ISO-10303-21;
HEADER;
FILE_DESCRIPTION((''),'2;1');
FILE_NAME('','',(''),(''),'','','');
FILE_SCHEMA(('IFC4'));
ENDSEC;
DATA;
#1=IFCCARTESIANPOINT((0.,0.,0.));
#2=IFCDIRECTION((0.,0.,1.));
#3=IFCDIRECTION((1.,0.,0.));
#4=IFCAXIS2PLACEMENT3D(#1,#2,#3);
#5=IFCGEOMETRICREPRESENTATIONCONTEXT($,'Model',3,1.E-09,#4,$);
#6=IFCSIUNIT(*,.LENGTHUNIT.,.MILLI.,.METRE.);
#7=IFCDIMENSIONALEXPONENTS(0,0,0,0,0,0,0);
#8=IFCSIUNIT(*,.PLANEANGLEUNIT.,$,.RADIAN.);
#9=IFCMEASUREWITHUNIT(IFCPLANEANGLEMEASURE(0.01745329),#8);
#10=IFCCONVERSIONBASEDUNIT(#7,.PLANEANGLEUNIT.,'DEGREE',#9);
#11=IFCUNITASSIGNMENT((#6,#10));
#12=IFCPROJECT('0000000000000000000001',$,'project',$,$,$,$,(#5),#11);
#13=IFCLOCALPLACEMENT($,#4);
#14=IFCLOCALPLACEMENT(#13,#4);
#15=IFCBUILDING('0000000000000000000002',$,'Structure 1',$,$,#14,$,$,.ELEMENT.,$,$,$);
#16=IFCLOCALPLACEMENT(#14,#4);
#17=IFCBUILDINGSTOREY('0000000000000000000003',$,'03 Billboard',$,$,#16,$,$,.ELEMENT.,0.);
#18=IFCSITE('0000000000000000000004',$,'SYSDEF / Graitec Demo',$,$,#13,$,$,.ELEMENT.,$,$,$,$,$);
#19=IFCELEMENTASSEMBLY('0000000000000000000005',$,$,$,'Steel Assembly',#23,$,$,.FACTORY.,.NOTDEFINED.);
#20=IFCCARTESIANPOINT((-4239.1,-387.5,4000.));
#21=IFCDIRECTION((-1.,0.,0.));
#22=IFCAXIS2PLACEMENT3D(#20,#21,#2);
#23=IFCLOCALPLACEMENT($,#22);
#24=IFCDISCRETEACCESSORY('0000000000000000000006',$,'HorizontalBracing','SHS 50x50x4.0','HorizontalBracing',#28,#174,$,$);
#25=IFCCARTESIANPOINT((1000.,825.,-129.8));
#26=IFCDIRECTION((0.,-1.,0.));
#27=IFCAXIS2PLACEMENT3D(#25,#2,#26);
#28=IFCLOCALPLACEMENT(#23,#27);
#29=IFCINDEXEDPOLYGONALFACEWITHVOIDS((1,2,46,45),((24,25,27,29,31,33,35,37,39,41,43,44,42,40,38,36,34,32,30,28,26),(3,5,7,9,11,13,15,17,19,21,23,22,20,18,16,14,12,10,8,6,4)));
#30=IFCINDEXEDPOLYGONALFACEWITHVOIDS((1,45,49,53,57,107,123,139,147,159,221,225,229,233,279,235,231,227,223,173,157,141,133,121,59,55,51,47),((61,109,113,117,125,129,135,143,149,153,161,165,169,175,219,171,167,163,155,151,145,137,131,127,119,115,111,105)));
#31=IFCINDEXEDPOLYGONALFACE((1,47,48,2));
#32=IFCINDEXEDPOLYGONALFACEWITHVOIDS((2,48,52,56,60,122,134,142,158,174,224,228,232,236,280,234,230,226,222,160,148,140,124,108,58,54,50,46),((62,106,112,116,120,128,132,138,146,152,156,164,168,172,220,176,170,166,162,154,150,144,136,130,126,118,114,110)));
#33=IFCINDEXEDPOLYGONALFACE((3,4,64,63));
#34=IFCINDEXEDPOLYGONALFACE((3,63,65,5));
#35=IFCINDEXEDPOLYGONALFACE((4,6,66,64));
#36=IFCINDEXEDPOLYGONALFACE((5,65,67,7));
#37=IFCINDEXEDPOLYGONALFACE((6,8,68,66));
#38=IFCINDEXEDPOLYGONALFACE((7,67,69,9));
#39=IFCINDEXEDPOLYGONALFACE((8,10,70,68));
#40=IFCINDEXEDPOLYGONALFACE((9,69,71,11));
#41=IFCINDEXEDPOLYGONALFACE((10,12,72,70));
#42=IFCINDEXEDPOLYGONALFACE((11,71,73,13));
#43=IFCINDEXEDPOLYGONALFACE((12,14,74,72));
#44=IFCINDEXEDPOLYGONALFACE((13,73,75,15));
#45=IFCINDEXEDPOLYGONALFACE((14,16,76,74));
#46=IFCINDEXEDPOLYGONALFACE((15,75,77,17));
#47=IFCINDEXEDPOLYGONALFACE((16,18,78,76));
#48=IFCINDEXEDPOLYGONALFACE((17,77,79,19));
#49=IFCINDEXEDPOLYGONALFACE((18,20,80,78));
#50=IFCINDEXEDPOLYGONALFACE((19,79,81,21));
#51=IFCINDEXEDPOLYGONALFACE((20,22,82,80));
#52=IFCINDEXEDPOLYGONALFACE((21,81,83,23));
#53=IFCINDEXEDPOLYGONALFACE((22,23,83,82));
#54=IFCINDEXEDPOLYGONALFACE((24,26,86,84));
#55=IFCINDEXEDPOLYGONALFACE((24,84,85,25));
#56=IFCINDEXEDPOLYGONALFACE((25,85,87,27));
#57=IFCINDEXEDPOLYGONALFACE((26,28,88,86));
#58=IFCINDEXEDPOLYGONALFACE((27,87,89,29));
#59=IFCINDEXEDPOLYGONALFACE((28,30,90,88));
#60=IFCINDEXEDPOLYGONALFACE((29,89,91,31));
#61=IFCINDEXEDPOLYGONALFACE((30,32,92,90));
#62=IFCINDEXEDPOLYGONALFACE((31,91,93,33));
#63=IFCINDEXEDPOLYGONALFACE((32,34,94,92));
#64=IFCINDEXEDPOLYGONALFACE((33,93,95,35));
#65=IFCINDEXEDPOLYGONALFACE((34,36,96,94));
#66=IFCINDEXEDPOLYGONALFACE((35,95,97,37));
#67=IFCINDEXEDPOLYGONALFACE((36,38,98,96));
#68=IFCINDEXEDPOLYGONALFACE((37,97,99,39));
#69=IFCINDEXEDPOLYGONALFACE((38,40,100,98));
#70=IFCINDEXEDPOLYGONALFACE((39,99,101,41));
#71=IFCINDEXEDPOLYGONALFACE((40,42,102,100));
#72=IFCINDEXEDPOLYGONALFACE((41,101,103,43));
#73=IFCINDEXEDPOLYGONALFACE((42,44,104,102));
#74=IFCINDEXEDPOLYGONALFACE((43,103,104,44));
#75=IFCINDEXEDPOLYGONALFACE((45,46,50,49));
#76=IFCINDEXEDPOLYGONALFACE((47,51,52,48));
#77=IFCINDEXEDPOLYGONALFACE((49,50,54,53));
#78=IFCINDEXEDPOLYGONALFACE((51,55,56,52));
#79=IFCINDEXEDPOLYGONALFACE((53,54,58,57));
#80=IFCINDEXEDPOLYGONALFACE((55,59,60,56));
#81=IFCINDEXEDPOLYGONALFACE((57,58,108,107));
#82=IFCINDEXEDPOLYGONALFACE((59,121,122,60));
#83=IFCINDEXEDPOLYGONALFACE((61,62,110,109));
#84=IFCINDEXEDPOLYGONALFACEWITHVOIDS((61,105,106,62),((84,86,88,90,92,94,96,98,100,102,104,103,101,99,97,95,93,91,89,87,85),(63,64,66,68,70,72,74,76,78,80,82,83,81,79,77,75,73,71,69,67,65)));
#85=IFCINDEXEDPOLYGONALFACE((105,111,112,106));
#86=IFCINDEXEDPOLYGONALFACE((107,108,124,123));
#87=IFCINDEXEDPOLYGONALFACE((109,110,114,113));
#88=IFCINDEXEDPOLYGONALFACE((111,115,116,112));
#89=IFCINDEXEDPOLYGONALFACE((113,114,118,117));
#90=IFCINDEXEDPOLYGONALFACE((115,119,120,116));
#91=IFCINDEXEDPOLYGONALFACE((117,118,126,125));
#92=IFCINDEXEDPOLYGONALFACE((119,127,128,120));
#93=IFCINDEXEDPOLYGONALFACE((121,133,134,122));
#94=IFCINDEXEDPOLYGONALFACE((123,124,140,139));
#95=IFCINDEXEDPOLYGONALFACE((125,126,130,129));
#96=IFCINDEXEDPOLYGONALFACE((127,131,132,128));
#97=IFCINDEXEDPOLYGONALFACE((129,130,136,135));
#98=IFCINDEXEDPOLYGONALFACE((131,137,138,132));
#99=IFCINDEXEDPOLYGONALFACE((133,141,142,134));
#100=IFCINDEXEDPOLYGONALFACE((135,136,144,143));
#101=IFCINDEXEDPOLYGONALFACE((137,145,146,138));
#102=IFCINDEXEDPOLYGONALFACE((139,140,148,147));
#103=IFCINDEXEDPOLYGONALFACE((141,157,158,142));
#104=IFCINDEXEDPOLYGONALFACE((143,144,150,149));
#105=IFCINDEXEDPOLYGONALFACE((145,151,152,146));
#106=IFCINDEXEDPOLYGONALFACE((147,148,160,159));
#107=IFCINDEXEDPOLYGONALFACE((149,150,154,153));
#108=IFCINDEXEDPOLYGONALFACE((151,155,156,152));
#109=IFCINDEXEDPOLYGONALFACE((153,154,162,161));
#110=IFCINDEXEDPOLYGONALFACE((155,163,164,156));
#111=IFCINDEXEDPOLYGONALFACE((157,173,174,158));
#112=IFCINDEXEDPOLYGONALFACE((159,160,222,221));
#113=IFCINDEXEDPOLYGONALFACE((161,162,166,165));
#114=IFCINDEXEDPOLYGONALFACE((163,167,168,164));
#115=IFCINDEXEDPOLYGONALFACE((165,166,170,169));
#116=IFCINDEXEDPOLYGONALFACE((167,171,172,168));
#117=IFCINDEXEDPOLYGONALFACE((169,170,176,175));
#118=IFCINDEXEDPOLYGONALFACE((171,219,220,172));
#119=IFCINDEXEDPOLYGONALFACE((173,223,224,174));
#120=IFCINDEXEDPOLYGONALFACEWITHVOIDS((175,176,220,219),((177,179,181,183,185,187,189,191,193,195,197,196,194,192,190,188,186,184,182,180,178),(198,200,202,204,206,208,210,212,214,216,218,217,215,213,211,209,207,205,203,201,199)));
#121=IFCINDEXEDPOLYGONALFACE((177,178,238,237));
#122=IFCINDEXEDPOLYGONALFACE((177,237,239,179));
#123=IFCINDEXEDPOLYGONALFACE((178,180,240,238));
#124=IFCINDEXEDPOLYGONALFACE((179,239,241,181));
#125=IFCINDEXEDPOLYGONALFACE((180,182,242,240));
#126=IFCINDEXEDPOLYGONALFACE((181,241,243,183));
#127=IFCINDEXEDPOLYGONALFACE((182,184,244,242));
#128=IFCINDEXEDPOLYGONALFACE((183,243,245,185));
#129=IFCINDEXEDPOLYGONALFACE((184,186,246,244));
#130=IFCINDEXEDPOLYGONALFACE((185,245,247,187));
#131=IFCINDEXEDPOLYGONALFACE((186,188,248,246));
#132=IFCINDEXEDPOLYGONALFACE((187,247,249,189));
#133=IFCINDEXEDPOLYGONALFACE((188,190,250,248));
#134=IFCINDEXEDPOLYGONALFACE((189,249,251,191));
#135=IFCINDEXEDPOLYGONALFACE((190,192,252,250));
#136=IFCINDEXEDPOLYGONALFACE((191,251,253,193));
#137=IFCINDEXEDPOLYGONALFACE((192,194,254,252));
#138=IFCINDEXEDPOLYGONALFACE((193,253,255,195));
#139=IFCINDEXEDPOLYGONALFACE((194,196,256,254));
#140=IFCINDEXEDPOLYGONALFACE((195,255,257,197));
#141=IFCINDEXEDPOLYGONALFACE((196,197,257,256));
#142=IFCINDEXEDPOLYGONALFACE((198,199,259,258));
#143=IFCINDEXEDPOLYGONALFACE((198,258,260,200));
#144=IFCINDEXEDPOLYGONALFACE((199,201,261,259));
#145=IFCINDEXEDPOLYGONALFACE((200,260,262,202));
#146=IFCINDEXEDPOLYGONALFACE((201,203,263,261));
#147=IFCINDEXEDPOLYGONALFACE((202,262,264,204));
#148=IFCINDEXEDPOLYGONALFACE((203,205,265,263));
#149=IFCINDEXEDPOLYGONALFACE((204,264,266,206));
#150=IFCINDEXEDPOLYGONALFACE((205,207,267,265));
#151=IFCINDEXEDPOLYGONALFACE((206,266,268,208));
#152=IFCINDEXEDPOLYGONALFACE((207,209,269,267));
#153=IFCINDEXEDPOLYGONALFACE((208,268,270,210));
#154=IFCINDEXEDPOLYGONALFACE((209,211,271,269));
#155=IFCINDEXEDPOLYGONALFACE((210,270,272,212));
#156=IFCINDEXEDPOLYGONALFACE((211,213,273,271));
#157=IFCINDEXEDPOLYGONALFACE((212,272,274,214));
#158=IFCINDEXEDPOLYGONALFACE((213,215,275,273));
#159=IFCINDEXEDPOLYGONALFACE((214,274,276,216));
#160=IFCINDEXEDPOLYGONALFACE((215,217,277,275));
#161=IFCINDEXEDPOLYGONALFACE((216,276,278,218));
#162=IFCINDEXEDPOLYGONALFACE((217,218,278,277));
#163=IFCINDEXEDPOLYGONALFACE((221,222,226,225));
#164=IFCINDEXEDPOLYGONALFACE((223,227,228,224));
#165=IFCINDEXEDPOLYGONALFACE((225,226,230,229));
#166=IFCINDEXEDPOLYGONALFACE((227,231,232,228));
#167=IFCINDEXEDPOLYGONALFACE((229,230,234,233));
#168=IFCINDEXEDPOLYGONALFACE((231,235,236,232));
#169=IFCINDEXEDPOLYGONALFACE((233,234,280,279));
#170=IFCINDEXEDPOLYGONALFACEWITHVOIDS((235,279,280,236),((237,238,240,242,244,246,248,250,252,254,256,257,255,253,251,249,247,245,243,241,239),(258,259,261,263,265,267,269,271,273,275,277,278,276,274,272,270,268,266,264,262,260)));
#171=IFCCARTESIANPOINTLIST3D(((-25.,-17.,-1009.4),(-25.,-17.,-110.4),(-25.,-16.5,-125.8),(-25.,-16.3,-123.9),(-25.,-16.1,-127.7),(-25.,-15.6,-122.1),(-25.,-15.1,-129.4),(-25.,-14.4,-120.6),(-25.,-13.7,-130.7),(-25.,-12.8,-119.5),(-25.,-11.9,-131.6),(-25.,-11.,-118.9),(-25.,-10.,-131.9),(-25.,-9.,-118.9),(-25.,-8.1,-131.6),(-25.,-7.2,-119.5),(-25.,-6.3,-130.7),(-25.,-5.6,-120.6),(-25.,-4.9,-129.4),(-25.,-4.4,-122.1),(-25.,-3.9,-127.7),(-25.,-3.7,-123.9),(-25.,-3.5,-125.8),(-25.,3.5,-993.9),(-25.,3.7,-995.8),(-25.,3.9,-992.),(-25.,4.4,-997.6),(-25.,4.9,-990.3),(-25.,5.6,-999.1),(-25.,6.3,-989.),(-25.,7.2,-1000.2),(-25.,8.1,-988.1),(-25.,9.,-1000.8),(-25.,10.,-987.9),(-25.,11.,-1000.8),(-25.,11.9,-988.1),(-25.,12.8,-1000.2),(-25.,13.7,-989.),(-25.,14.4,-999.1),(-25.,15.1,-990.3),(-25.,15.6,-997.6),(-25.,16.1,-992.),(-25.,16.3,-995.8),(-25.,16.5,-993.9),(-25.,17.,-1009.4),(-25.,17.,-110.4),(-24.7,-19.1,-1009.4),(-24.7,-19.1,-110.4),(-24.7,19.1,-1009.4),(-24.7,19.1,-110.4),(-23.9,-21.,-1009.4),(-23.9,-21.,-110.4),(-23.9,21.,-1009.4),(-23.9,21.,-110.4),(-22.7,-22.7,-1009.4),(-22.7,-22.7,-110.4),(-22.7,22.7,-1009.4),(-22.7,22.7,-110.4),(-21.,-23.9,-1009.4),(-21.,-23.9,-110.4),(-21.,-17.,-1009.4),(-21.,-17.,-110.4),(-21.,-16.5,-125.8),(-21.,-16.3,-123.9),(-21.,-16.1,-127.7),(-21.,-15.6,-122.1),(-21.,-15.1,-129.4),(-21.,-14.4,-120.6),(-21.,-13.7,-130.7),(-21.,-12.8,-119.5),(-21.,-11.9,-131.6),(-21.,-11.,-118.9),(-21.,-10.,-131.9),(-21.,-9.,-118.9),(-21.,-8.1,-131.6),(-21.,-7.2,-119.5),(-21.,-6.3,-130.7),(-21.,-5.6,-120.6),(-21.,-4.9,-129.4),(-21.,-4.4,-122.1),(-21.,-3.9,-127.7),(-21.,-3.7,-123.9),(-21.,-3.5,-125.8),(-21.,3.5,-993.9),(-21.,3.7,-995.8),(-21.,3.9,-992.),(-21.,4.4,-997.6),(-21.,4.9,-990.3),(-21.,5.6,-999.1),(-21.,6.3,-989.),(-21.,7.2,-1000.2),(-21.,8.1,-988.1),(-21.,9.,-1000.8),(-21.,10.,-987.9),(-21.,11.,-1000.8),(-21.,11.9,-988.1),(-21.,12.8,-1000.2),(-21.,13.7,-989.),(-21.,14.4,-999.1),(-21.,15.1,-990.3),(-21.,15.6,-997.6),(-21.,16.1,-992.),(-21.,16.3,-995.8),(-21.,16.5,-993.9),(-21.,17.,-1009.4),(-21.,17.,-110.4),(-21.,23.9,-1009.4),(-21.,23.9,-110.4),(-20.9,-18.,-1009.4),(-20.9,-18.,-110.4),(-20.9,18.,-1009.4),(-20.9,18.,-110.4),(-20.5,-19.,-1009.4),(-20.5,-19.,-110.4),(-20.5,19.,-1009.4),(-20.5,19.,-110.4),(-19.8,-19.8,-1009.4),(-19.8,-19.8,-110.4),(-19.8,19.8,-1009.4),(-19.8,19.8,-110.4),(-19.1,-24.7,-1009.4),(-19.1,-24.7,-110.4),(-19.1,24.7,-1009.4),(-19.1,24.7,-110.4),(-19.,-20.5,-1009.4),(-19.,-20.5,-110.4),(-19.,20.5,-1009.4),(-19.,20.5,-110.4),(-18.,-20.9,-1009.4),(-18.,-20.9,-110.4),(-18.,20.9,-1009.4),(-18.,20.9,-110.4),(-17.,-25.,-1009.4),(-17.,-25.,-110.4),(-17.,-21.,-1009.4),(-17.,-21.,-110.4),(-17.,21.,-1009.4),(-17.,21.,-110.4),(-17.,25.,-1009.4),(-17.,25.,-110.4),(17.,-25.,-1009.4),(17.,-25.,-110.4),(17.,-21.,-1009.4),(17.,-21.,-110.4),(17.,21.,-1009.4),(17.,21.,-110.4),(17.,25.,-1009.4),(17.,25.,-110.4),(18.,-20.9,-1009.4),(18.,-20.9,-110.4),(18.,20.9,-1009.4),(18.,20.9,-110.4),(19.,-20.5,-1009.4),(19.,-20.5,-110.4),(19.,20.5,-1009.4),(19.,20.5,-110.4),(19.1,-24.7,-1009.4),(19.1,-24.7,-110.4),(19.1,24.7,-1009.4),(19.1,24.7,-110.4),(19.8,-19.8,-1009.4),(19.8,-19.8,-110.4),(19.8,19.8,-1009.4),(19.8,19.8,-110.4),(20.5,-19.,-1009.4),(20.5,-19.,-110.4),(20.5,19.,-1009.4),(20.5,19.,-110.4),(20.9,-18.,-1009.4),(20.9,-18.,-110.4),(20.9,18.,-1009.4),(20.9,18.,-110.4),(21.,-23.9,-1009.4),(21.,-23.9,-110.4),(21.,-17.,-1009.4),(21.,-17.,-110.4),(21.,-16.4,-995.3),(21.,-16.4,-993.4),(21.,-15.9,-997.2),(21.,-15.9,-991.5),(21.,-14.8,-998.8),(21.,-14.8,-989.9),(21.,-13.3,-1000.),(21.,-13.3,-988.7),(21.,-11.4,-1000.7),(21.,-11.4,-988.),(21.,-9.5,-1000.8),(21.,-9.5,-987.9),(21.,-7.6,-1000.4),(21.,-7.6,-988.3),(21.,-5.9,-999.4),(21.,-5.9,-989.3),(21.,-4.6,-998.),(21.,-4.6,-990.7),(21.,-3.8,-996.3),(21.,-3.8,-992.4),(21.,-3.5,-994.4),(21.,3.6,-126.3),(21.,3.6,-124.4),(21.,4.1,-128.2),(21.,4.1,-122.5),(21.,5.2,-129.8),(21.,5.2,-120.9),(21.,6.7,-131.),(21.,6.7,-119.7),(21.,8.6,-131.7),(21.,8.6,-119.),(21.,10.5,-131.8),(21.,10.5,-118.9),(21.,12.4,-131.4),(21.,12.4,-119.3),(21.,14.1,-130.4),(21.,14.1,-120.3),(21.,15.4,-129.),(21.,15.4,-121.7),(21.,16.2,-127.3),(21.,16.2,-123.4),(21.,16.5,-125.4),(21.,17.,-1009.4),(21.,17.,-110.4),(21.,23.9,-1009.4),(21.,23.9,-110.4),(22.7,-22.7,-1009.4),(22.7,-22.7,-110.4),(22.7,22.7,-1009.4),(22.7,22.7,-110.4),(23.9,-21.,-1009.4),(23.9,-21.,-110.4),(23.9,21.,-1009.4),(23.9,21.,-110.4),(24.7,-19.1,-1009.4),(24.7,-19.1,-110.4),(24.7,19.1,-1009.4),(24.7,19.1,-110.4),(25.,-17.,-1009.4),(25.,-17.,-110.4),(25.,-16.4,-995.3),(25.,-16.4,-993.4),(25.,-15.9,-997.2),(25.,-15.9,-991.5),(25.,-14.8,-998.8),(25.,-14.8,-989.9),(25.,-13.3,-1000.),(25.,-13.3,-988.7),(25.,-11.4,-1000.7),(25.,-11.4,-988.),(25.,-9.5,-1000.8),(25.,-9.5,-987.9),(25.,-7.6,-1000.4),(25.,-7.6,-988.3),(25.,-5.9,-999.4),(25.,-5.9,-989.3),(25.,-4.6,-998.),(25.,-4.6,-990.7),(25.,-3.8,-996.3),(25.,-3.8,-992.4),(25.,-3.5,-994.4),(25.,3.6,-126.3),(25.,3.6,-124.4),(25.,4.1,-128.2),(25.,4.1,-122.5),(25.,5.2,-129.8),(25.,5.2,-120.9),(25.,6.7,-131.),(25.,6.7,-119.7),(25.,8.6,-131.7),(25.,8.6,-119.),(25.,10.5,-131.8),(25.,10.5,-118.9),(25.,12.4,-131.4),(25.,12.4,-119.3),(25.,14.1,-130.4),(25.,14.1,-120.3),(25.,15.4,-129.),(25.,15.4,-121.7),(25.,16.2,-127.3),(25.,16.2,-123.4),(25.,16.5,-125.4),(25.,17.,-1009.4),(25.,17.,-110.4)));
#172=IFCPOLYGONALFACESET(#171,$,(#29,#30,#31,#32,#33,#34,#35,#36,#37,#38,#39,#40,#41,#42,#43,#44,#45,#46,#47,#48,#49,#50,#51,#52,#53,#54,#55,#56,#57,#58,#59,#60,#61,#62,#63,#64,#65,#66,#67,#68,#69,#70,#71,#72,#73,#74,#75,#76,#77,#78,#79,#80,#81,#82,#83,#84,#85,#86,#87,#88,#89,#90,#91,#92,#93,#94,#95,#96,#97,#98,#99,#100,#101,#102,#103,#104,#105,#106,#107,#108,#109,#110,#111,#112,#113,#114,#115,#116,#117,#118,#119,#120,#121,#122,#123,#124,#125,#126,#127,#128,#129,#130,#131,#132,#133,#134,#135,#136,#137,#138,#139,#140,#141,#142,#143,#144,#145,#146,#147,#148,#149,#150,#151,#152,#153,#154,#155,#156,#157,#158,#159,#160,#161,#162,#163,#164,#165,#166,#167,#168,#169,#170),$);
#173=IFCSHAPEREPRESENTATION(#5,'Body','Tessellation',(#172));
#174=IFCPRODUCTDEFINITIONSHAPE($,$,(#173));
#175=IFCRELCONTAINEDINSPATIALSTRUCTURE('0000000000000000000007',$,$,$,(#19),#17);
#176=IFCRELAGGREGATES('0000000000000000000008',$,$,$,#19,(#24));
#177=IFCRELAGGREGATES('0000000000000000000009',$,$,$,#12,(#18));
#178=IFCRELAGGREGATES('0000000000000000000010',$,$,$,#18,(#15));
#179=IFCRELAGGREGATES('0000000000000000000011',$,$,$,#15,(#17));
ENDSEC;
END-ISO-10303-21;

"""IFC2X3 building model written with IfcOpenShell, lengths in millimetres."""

from ifc_helpers import new_model, entity, si_unit, converted_unit, frame, frame_2d, origin, origin_with_axes, origin_2d, origin_2d_with_axis, place, context, project, spatial, hollow_rectangle, circle, extrude, clip, halfspace, element, aggregate, save


model = new_model("IFC2X3")

# Units and contexts
model_context = context("Model", 3, precision=1e-09, world=origin_with_axes())
ifc_project = project(units=[si_unit("LENGTHUNIT", "METRE", prefix="MILLI"), converted_unit("PLANEANGLEUNIT", "DEGREE", entity("IfcPlaneAngleMeasure", 0.01745329), si_unit("PLANEANGLEUNIT", "RADIAN"), dimensions=[0, 0, 0, 0, 0, 0, 0])], contexts=[model_context])

# Site, building, storey
site_placement = place(None, origin_with_axes())
site = spatial("IfcSite", under=ifc_project, at=site_placement, Name="SYSDEF / Graitec Demo", CompositionType="ELEMENT")
building_placement = place(site_placement, origin_with_axes())
building = spatial("IfcBuilding", under=site, at=building_placement, Name="Structure 1", CompositionType="ELEMENT")
storey_placement = place(building_placement, origin_with_axes())
storey = spatial("IfcBuildingStorey", under=building, at=storey_placement, Name="03 Billboard", CompositionType="ELEMENT", Elevation=0.0)

# Element assembly, discrete accessory, openings
assembly_1_placement = place(None, frame((-4239.1, -387.5, 4000.0), z_axis=(-1.0, 0.0, 0.0), x_axis=(0.0, 0.0, 1.0)))
assembly_1 = element("IfcElementAssembly", 1, at=assembly_1_placement, inside=storey, ObjectType="Steel Assembly", AssemblyPlace="FACTORY", PredefinedType="NOTDEFINED")
discrete_accessory_1_placement = place(assembly_1_placement, frame((1000.0, 825.0, -129.8), z_axis=(0.0, 0.0, 1.0), x_axis=(0.0, -1.0, 0.0)))
discrete_accessory_1 = element("IfcDiscreteAccessory", 2, at=discrete_accessory_1_placement, Name="HorizontalBracing", Description="SHS 50x50x4.0", ObjectType="HorizontalBracing", context=model_context, shape_type="Clipping", body=[
    clip(clip(extrude(hollow_rectangle(XDim=50.0, YDim=50.0, WallThickness=4.0, InnerFilletRadius=4.0, OuterFilletRadius=8.0, at=origin_2d()), origin(), (0.0, 0.0, -1.0), 1119.7), halfspace(frame((437.5, -5000.0, -1009.4), z_axis=(0.0, 0.0, 1.0), x_axis=(1.0, 0.0, 0.0)), True)), halfspace(frame((437.5, -5000.0, -110.4), z_axis=(0.0, 0.0, -1.0), x_axis=(-1.0, 0.0, 0.0)), True)),
])
opening_1_placement = place(discrete_accessory_1_placement, frame((-20.5, 10.0, -994.4), z_axis=(-1.0, 0.0, 0.0), x_axis=(0.0, 0.0, 1.0)))
element("IfcOpeningElement", 3, at=opening_1_placement, cuts=discrete_accessory_1, ObjectType="Opening", context=model_context, shape_type="SweptSolid", body=[
    extrude(circle(Radius=6.5, at=origin_2d_with_axis()), origin(), (0.0, 0.0, 1.0), 5.0),
])
opening_2_placement = place(discrete_accessory_1_placement, frame((25.5, -10.0, -1000.9), z_axis=(1.0, 0.0, 0.0), x_axis=(0.0, 1.0, 0.0)))
element("IfcOpeningElement", 4, at=opening_2_placement, cuts=discrete_accessory_1, ObjectType="Opening", context=model_context, shape_type="SweptSolid", body=[
    extrude(circle(Radius=6.5, at=frame_2d((0.0, 6.5), x_axis=(1.0, 0.0))), origin(), (0.0, 0.0, -1.0), 5.0),
])
opening_3_placement = place(discrete_accessory_1_placement, frame((-20.5, -10.0, -125.4), z_axis=(-1.0, 0.0, 0.0), x_axis=(0.0, 0.0, -1.0)))
element("IfcOpeningElement", 5, at=opening_3_placement, cuts=discrete_accessory_1, ObjectType="Opening", context=model_context, shape_type="SweptSolid", body=[
    extrude(circle(Radius=6.5, at=origin_2d_with_axis()), origin(), (0.0, 0.0, 1.0), 5.0),
])
opening_4_placement = place(discrete_accessory_1_placement, frame((25.5, 10.0, -118.9), z_axis=(1.0, 0.0, 0.0), x_axis=(0.0, 1.0, 0.0)))
element("IfcOpeningElement", 6, at=opening_4_placement, cuts=discrete_accessory_1, ObjectType="Opening", context=model_context, shape_type="SweptSolid", body=[
    extrude(circle(Radius=6.5, at=frame_2d((0.0, -6.5), x_axis=(1.0, 0.0))), origin(), (0.0, 0.0, -1.0), 5.0),
])
aggregate(assembly_1, [discrete_accessory_1])

save(model, "model.ifc")
